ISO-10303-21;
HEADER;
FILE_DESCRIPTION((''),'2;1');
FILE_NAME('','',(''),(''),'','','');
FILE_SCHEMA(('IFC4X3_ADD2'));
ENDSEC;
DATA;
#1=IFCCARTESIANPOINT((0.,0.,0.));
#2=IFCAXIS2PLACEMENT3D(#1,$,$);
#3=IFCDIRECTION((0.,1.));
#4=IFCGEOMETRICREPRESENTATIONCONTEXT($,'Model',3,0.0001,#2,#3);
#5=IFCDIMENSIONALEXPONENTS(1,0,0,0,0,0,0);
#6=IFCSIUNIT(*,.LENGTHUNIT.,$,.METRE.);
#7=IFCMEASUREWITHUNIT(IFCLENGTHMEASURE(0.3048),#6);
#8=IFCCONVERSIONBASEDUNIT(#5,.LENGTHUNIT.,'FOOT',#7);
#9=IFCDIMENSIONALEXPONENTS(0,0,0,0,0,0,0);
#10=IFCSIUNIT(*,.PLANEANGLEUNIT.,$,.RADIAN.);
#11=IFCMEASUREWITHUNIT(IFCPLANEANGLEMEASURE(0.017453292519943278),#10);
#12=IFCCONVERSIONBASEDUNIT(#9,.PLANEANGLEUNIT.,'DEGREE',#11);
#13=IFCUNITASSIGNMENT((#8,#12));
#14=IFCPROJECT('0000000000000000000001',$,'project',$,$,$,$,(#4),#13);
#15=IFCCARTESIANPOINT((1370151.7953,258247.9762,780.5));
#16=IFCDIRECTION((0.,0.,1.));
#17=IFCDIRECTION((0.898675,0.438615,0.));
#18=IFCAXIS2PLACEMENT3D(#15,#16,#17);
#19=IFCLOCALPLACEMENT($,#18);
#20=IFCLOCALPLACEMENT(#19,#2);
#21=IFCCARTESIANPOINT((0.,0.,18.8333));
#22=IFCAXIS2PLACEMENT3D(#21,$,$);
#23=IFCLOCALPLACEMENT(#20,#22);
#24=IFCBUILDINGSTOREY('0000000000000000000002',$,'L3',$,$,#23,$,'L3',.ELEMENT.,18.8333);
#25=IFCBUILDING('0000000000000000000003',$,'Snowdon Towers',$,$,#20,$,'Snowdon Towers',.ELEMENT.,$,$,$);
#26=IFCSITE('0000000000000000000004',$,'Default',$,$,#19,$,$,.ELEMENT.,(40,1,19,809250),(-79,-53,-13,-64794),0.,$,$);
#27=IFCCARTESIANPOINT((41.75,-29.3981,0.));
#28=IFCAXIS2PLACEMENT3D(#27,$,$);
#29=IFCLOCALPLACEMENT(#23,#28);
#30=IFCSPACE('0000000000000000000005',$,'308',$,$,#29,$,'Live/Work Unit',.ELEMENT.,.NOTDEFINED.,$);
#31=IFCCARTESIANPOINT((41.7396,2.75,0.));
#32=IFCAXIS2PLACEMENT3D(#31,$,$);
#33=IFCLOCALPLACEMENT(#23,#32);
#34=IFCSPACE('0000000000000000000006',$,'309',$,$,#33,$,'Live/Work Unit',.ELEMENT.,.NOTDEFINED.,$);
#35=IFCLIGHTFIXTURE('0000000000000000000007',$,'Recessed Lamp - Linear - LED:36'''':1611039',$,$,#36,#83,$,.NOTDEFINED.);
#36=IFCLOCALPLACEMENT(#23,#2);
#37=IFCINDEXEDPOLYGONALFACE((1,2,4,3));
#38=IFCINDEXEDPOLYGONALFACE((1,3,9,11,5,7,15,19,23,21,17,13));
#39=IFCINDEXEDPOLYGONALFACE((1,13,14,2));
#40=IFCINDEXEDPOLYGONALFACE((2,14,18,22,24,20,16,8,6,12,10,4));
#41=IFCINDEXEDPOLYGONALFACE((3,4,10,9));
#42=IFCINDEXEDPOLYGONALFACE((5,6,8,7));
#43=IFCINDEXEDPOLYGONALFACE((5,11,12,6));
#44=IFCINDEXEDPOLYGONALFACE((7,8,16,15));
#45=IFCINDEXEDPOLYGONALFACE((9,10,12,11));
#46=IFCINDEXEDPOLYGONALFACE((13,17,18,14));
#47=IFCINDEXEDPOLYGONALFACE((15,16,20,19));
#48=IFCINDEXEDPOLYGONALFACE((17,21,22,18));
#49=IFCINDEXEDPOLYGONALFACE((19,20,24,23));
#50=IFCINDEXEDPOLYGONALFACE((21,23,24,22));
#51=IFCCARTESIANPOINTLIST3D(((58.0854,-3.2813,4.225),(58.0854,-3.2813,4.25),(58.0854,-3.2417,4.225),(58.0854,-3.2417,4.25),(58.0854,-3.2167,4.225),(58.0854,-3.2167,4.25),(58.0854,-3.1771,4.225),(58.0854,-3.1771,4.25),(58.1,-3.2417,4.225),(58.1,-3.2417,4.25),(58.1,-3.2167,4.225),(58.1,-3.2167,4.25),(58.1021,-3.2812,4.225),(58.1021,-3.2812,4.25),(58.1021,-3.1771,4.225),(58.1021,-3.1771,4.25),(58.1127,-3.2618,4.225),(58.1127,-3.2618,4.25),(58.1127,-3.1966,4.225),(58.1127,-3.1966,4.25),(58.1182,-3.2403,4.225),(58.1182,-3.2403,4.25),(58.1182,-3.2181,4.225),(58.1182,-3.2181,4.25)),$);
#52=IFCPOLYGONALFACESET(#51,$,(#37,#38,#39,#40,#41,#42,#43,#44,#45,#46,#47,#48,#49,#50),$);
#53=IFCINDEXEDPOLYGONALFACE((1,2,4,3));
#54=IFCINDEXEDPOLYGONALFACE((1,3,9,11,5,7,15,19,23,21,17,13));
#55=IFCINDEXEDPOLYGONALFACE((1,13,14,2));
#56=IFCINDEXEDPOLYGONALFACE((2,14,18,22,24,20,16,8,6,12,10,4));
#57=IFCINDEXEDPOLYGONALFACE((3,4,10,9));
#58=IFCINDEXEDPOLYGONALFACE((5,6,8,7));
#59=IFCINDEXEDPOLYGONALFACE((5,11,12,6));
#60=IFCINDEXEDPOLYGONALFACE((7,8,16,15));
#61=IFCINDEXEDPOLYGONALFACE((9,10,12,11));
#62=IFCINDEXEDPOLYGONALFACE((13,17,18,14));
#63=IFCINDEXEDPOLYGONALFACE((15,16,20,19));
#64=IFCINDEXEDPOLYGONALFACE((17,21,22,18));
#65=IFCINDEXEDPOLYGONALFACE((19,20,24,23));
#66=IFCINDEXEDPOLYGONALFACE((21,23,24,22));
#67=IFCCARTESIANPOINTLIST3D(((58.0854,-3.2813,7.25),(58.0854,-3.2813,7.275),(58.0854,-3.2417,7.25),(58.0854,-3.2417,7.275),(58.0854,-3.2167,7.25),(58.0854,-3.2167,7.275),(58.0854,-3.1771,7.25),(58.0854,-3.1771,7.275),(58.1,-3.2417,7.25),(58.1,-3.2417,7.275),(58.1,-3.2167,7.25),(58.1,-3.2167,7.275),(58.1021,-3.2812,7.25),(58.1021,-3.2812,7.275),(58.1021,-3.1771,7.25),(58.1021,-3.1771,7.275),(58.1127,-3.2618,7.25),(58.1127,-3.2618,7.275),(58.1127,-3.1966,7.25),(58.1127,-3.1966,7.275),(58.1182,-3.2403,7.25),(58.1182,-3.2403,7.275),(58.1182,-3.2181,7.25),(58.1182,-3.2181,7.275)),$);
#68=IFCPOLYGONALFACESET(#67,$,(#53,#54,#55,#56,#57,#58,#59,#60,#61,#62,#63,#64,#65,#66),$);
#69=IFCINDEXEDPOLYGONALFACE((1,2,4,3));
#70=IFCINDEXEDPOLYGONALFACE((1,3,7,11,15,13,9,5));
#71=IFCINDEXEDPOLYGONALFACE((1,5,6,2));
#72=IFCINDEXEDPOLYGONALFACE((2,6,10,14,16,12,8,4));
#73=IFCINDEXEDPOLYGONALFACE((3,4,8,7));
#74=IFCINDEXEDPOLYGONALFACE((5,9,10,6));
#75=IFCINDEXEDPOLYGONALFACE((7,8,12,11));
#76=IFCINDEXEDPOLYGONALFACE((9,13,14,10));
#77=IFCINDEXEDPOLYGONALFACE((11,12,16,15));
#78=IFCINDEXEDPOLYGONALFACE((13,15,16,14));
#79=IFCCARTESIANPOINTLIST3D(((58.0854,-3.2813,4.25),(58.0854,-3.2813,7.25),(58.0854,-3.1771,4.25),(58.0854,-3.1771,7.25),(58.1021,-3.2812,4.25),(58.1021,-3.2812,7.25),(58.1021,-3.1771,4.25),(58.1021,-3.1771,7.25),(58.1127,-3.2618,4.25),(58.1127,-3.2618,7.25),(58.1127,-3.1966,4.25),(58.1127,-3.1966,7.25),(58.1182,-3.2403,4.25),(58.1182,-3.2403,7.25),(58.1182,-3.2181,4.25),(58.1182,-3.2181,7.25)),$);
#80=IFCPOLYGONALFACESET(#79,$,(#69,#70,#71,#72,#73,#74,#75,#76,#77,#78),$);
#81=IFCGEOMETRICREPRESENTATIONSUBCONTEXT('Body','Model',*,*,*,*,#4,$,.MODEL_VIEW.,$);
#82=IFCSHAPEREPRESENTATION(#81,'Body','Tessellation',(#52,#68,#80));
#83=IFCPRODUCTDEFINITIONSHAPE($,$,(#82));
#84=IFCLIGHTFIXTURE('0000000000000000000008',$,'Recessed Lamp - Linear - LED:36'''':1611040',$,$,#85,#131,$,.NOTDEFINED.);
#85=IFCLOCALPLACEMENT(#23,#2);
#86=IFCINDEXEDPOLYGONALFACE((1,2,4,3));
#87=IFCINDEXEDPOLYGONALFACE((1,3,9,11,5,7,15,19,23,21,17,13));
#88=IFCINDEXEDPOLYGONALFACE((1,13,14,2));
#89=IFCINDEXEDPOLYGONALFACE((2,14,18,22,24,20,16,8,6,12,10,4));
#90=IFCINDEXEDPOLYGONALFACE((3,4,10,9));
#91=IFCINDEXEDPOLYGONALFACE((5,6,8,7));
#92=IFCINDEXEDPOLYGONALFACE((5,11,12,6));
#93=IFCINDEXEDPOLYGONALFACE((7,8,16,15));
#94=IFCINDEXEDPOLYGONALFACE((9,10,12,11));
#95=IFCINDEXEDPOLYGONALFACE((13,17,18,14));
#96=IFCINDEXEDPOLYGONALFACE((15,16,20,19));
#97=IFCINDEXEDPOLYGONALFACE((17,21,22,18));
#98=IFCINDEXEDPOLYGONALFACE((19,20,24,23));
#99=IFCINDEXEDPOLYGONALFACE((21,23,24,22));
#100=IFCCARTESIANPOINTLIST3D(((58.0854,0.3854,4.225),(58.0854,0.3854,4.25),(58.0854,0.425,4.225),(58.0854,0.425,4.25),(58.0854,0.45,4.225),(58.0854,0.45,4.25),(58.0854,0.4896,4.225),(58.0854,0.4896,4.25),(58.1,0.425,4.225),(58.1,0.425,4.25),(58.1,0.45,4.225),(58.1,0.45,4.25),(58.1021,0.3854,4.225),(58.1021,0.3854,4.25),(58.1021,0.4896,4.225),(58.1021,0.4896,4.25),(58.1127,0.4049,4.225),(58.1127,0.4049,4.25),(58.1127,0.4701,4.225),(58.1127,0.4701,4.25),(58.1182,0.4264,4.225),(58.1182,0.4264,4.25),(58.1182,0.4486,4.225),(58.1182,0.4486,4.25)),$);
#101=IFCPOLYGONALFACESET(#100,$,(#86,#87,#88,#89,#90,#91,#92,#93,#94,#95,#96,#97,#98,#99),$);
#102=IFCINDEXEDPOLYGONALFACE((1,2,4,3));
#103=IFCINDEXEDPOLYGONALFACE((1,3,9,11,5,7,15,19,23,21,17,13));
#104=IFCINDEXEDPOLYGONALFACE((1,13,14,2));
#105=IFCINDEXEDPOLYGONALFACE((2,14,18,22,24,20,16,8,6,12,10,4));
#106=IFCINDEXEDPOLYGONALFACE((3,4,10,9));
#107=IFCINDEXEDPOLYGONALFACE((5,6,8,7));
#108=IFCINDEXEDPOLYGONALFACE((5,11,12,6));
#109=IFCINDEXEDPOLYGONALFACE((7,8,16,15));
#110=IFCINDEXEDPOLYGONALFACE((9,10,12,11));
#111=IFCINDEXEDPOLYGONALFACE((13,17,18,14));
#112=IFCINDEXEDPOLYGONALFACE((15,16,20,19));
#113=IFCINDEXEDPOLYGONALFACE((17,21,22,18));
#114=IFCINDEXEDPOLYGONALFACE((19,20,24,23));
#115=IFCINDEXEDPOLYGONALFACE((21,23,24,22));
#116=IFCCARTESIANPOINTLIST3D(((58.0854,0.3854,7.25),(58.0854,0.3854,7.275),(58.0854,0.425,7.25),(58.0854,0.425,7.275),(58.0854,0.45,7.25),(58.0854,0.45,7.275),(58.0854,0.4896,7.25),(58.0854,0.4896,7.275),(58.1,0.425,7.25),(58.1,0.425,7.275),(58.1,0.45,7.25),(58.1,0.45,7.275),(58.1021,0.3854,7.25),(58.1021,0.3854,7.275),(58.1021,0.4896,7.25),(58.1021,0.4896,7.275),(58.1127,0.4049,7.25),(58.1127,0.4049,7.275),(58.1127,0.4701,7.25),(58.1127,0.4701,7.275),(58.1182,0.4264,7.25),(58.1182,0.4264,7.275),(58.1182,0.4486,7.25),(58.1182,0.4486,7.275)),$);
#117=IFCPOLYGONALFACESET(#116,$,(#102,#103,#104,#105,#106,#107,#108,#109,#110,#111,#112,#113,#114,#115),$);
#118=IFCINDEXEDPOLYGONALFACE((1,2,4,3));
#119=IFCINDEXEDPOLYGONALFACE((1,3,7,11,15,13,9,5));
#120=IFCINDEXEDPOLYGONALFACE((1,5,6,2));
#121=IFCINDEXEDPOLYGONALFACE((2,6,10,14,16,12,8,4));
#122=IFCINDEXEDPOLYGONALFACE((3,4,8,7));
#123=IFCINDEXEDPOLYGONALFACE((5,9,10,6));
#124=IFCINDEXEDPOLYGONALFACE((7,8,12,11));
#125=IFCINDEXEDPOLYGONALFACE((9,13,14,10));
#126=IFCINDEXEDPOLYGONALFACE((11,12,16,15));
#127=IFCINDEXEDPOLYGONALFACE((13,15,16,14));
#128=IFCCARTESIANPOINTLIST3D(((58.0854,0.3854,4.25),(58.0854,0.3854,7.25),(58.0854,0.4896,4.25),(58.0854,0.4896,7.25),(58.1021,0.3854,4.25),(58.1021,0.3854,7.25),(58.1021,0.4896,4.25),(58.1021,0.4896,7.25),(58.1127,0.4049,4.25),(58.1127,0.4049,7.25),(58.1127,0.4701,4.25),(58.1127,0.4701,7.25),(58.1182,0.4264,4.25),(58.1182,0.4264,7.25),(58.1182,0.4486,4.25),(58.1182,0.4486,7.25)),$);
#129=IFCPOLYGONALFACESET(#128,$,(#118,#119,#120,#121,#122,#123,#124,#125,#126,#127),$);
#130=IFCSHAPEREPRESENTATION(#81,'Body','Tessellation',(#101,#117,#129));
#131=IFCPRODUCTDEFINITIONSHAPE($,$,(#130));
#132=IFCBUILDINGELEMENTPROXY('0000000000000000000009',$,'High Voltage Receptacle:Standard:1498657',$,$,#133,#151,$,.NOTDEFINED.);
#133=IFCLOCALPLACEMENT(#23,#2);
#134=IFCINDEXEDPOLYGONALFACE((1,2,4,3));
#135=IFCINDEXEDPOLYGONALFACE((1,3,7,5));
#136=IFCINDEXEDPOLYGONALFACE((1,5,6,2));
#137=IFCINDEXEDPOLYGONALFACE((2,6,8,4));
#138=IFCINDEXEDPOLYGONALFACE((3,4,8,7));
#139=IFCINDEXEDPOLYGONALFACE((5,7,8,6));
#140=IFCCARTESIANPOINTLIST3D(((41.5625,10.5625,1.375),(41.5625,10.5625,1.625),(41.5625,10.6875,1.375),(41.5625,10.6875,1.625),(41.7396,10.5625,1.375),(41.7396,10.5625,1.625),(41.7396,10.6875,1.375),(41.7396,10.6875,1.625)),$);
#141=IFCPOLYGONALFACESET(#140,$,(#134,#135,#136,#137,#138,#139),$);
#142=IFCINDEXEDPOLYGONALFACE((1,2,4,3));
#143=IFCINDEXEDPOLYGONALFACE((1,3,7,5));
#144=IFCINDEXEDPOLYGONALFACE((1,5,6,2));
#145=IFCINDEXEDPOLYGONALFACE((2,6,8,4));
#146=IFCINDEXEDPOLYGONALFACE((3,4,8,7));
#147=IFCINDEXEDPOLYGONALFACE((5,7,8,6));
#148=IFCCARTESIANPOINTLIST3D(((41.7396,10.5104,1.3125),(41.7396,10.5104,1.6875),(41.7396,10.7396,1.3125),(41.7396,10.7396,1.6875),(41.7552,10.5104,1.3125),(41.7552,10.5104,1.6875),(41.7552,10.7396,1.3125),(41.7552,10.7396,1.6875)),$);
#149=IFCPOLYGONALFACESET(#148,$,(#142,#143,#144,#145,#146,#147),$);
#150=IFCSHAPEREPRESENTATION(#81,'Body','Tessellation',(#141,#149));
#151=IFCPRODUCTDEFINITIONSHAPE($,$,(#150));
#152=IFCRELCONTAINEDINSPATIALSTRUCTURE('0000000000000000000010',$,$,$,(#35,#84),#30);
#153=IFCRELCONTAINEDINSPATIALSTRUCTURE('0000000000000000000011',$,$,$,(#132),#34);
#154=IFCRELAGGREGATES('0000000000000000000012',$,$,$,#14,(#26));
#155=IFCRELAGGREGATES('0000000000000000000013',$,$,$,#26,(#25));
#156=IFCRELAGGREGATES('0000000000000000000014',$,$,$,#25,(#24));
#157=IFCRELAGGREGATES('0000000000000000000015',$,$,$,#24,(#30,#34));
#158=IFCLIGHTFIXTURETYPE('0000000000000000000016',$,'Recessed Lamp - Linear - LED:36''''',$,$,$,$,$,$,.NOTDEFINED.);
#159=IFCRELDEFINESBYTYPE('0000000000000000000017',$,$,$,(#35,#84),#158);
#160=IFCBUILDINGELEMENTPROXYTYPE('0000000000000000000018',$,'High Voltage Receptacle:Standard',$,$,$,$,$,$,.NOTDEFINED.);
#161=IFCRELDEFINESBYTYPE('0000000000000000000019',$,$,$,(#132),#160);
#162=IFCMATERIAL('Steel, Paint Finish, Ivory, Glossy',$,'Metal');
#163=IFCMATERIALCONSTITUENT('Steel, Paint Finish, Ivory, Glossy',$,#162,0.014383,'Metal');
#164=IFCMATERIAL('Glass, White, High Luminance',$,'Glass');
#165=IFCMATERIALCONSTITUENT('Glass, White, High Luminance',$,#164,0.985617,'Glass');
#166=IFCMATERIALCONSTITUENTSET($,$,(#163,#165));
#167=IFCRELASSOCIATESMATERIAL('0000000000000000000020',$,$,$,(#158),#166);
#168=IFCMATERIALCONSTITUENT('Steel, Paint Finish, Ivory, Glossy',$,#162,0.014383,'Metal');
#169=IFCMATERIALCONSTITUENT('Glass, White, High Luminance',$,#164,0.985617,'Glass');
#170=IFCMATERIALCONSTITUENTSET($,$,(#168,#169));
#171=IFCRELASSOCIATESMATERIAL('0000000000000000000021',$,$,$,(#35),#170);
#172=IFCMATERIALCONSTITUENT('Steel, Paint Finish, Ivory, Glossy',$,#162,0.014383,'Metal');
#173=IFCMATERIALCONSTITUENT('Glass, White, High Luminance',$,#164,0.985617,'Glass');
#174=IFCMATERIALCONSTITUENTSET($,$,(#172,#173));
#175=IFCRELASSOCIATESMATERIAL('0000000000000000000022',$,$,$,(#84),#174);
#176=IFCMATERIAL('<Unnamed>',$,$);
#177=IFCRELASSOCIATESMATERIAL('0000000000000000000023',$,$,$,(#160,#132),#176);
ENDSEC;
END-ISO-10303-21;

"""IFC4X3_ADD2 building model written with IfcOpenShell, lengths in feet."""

from ifc_helpers import new_model, entity, si_unit, converted_unit, direction, frame, frame_2d, origin, origin_2d_with_axis, place, context, subcontext, project, spatial, polyline, circle_curve, parameter, trimmed, segment, composite_curve, rectangle, outline, extrude, source, transform, mapped, material, constituent, constituent_set, type_object, type_shapes, element, save


model = new_model("IFC4X3_ADD2")

# Units and contexts
model_context = context("Model", 3, precision=0.0001, world=origin(), true_north=direction((0.0, 1.0)))
body_context = subcontext(model_context, "Body", "Model", "MODEL_VIEW")
ifc_project = project(units=[converted_unit("LENGTHUNIT", "FOOT", entity("IfcLengthMeasure", 0.3048), si_unit("LENGTHUNIT", "METRE"), dimensions=[1, 0, 0, 0, 0, 0, 0]), converted_unit("PLANEANGLEUNIT", "DEGREE", entity("IfcPlaneAngleMeasure", 0.017453292519943278), si_unit("PLANEANGLEUNIT", "RADIAN"), dimensions=[0, 0, 0, 0, 0, 0, 0])], contexts=[model_context])

# Site, building, storey
site_placement = place(None, frame((1370151.7953, 258247.9762, 780.5), z_axis=(0.0, 0.0, 1.0), x_axis=(0.898675, 0.438615, 0.0)))
site = spatial("IfcSite", under=ifc_project, at=site_placement, Name="Default", CompositionType="ELEMENT", RefLatitude=(40, 1, 19, 809250), RefLongitude=(-79, -53, -13, -64794), RefElevation=0.0)
building_placement = place(site_placement, origin())
building = spatial("IfcBuilding", under=site, at=building_placement, Name="Snowdon Towers", LongName="Snowdon Towers", CompositionType="ELEMENT")
storey_placement = place(building_placement, frame((0.0, 0.0, 18.8333)))
storey = spatial("IfcBuildingStorey", under=building, at=storey_placement, Name="L3", LongName="L3", CompositionType="ELEMENT", Elevation=18.8333)

# Shared definitions
ifc_material_1 = material(Name="Steel, Paint Finish, Ivory, Glossy", Category="Metal")
ifc_material_2 = material(Name="Glass, White, High Luminance", Category="Glass")
ifc_constituent_1 = constituent(ifc_material_1, Name="Steel, Paint Finish, Ivory, Glossy", Category="Metal", fraction=0.014383)
ifc_constituent_2 = constituent(ifc_material_2, Name="Glass, White, High Luminance", Category="Glass", fraction=0.985617)
ifc_constituent_set_1 = constituent_set(constituents=[ifc_constituent_1, ifc_constituent_2])
light_fixture_type = type_object("IfcLightFixtureType", Name="Recessed Lamp - Linear - LED:36''", PredefinedType="NOTDEFINED", material=ifc_constituent_set_1)
shared_shape_1 = source(origin(), body_context, "Body", "SweptSolid", [
    extrude(outline(composite_curve([segment(trimmed(circle_curve(frame_2d((0.0, -0.0633), x_axis=(1.0, 0.0)), 0.089), [parameter(54.196986)], [parameter(125.803014)], True, "PARAMETER"), True, "CONTINUOUS"), segment(polyline([(-0.0521, 0.0089), (-0.0521, -0.0078)]), True, "CONTINUOUS"), segment(polyline([(-0.0521, -0.0078), (-0.0125, -0.0078)]), True, "CONTINUOUS"), segment(polyline([(-0.0125, -0.0078), (-0.0125, 0.0068)]), True, "CONTINUOUS"), segment(polyline([(-0.0125, 0.0068), (0.0125, 0.0068)]), True, "CONTINUOUS"), segment(polyline([(0.0125, 0.0068), (0.0125, -0.0078)]), True, "CONTINUOUS"), segment(polyline([(0.0125, -0.0078), (0.0521, -0.0078)]), True, "CONTINUOUS"), segment(polyline([(0.0521, -0.0078), (0.0521, 0.0089)]), True, "CONTINUOUS")], self_intersect=False)), frame((-1.525, 0.0, 0.0078), z_axis=(1.0, 0.0, 0.0), x_axis=(0.0, 1.0, 0.0)), (0.0, 0.0, 1.0), 0.025),
    extrude(outline(composite_curve([segment(trimmed(circle_curve(frame_2d((0.0, -0.0633), x_axis=(1.0, 0.0)), 0.089), [parameter(54.196986)], [parameter(125.803014)], True, "PARAMETER"), True, "CONTINUOUS"), segment(polyline([(-0.0521, 0.0089), (-0.0521, -0.0078)]), True, "CONTINUOUS"), segment(polyline([(-0.0521, -0.0078), (-0.0125, -0.0078)]), True, "CONTINUOUS"), segment(polyline([(-0.0125, -0.0078), (-0.0125, 0.0068)]), True, "CONTINUOUS"), segment(polyline([(-0.0125, 0.0068), (0.0125, 0.0068)]), True, "CONTINUOUS"), segment(polyline([(0.0125, 0.0068), (0.0125, -0.0078)]), True, "CONTINUOUS"), segment(polyline([(0.0125, -0.0078), (0.0521, -0.0078)]), True, "CONTINUOUS"), segment(polyline([(0.0521, -0.0078), (0.0521, 0.0089)]), True, "CONTINUOUS")], self_intersect=False)), frame((1.5, 0.0, 0.0078), z_axis=(1.0, 0.0, 0.0), x_axis=(0.0, 1.0, 0.0)), (0.0, 0.0, 1.0), 0.025),
    extrude(outline(composite_curve([segment(trimmed(circle_curve(frame_2d((0.0, -0.0639), x_axis=(1.0, 0.0)), 0.089), [parameter(54.196986)], [parameter(125.803014)], True, "PARAMETER"), True, "CONTINUOUS"), segment(polyline([(-0.0521, 0.0083), (-0.0521, -0.0083)]), True, "CONTINUOUS"), segment(polyline([(-0.0521, -0.0083), (0.0521, -0.0083)]), True, "CONTINUOUS"), segment(polyline([(0.0521, -0.0083), (0.0521, 0.0083)]), True, "CONTINUOUS")], self_intersect=False)), frame((-1.5, 0.0, 0.0083), z_axis=(1.0, 0.0, 0.0), x_axis=(0.0, 1.0, 0.0)), (0.0, 0.0, 1.0), 3.0),
])
type_shapes(light_fixture_type, [shared_shape_1])

# Shared definitions
space_1_placement = place(storey_placement, frame((41.75, -29.3981, 0.0)))
space_1 = spatial("IfcSpace", under=storey, at=space_1_placement, Name="308", LongName="Live/Work Unit", CompositionType="ELEMENT", PredefinedType="NOTDEFINED")

# Light fixtures
ifc_constituent_3 = constituent(ifc_material_1, Name="Steel, Paint Finish, Ivory, Glossy", Category="Metal", fraction=0.014383)
ifc_constituent_4 = constituent(ifc_material_2, Name="Glass, White, High Luminance", Category="Glass", fraction=0.985617)
ifc_constituent_set_2 = constituent_set(constituents=[ifc_constituent_3, ifc_constituent_4])
light_fixture_1_placement = place(space_1_placement, frame((16.3354, 26.169, 5.75), z_axis=(1.0, 0.0, 0.0), x_axis=(0.0, 0.0, 1.0)))
element("IfcLightFixture", 1, at=light_fixture_1_placement, inside=space_1, type_object=light_fixture_type, material=ifc_constituent_set_2, Name="Recessed Lamp - Linear - LED:36'':1611039", PredefinedType="NOTDEFINED", context=body_context, shape_type="MappedRepresentation", body=[
    mapped(shared_shape_1, transform((0.0, 0.0, 0.0), scale=1.0)),
])
ifc_constituent_5 = constituent(ifc_material_1, Name="Steel, Paint Finish, Ivory, Glossy", Category="Metal", fraction=0.014383)
ifc_constituent_6 = constituent(ifc_material_2, Name="Glass, White, High Luminance", Category="Glass", fraction=0.985617)
ifc_constituent_set_3 = constituent_set(constituents=[ifc_constituent_5, ifc_constituent_6])
light_fixture_2_placement = place(space_1_placement, frame((16.3354, 29.8356, 5.75), z_axis=(1.0, 0.0, 0.0), x_axis=(0.0, 0.0, 1.0)))
element("IfcLightFixture", 2, at=light_fixture_2_placement, inside=space_1, type_object=light_fixture_type, material=ifc_constituent_set_3, Name="Recessed Lamp - Linear - LED:36'':1611040", PredefinedType="NOTDEFINED", context=body_context, shape_type="MappedRepresentation", body=[
    mapped(shared_shape_1, transform((0.0, 0.0, 0.0), scale=1.0)),
])

# Shared definitions
ifc_material_3 = material(Name="<Unnamed>")

# Shared definitions
building_element_proxy_type_1 = type_object("IfcBuildingElementProxyType", Name="High Voltage Receptacle:Standard", PredefinedType="NOTDEFINED", material=ifc_material_3)
shared_shape_2 = source(origin(), body_context, "Body", "SweptSolid", [
    extrude(rectangle(XDim=0.125, YDim=0.25, at=origin_2d_with_axis()), frame((0.0, 0.0, -0.1771), z_axis=(0.0, 0.0, 1.0), x_axis=(-1.0, 0.0, 0.0)), (0.0, 0.0, 1.0), 0.1771),
    extrude(rectangle(XDim=0.2292, YDim=0.375, at=frame_2d((0.0, 0.0), x_axis=(1.0, 0.0))), frame((0.0, 0.0, 0.0), z_axis=(0.0, 0.0, 1.0), x_axis=(-1.0, 0.0, 0.0)), (0.0, 0.0, 1.0), 0.0156),
])
type_shapes(building_element_proxy_type_1, [shared_shape_2])

# Shared definitions
space_2_placement = place(storey_placement, frame((41.7396, 2.75, 0.0)))
space_2 = spatial("IfcSpace", under=storey, at=space_2_placement, Name="309", LongName="Live/Work Unit", CompositionType="ELEMENT", PredefinedType="NOTDEFINED")

# Building element proxy
proxy_1_placement = place(space_2_placement, frame((0.0, 7.875, 1.5), z_axis=(1.0, 0.0, 0.0), x_axis=(0.0, 1.0, 0.0)))
element("IfcBuildingElementProxy", 3, at=proxy_1_placement, inside=space_2, type_object=building_element_proxy_type_1, material=ifc_material_3, Name="High Voltage Receptacle:Standard:1498657", PredefinedType="NOTDEFINED", context=body_context, shape_type="MappedRepresentation", body=[
    mapped(shared_shape_2, transform((0.0, 0.0, 0.0), scale=1.0)),
])

save(model, "model.ifc")
